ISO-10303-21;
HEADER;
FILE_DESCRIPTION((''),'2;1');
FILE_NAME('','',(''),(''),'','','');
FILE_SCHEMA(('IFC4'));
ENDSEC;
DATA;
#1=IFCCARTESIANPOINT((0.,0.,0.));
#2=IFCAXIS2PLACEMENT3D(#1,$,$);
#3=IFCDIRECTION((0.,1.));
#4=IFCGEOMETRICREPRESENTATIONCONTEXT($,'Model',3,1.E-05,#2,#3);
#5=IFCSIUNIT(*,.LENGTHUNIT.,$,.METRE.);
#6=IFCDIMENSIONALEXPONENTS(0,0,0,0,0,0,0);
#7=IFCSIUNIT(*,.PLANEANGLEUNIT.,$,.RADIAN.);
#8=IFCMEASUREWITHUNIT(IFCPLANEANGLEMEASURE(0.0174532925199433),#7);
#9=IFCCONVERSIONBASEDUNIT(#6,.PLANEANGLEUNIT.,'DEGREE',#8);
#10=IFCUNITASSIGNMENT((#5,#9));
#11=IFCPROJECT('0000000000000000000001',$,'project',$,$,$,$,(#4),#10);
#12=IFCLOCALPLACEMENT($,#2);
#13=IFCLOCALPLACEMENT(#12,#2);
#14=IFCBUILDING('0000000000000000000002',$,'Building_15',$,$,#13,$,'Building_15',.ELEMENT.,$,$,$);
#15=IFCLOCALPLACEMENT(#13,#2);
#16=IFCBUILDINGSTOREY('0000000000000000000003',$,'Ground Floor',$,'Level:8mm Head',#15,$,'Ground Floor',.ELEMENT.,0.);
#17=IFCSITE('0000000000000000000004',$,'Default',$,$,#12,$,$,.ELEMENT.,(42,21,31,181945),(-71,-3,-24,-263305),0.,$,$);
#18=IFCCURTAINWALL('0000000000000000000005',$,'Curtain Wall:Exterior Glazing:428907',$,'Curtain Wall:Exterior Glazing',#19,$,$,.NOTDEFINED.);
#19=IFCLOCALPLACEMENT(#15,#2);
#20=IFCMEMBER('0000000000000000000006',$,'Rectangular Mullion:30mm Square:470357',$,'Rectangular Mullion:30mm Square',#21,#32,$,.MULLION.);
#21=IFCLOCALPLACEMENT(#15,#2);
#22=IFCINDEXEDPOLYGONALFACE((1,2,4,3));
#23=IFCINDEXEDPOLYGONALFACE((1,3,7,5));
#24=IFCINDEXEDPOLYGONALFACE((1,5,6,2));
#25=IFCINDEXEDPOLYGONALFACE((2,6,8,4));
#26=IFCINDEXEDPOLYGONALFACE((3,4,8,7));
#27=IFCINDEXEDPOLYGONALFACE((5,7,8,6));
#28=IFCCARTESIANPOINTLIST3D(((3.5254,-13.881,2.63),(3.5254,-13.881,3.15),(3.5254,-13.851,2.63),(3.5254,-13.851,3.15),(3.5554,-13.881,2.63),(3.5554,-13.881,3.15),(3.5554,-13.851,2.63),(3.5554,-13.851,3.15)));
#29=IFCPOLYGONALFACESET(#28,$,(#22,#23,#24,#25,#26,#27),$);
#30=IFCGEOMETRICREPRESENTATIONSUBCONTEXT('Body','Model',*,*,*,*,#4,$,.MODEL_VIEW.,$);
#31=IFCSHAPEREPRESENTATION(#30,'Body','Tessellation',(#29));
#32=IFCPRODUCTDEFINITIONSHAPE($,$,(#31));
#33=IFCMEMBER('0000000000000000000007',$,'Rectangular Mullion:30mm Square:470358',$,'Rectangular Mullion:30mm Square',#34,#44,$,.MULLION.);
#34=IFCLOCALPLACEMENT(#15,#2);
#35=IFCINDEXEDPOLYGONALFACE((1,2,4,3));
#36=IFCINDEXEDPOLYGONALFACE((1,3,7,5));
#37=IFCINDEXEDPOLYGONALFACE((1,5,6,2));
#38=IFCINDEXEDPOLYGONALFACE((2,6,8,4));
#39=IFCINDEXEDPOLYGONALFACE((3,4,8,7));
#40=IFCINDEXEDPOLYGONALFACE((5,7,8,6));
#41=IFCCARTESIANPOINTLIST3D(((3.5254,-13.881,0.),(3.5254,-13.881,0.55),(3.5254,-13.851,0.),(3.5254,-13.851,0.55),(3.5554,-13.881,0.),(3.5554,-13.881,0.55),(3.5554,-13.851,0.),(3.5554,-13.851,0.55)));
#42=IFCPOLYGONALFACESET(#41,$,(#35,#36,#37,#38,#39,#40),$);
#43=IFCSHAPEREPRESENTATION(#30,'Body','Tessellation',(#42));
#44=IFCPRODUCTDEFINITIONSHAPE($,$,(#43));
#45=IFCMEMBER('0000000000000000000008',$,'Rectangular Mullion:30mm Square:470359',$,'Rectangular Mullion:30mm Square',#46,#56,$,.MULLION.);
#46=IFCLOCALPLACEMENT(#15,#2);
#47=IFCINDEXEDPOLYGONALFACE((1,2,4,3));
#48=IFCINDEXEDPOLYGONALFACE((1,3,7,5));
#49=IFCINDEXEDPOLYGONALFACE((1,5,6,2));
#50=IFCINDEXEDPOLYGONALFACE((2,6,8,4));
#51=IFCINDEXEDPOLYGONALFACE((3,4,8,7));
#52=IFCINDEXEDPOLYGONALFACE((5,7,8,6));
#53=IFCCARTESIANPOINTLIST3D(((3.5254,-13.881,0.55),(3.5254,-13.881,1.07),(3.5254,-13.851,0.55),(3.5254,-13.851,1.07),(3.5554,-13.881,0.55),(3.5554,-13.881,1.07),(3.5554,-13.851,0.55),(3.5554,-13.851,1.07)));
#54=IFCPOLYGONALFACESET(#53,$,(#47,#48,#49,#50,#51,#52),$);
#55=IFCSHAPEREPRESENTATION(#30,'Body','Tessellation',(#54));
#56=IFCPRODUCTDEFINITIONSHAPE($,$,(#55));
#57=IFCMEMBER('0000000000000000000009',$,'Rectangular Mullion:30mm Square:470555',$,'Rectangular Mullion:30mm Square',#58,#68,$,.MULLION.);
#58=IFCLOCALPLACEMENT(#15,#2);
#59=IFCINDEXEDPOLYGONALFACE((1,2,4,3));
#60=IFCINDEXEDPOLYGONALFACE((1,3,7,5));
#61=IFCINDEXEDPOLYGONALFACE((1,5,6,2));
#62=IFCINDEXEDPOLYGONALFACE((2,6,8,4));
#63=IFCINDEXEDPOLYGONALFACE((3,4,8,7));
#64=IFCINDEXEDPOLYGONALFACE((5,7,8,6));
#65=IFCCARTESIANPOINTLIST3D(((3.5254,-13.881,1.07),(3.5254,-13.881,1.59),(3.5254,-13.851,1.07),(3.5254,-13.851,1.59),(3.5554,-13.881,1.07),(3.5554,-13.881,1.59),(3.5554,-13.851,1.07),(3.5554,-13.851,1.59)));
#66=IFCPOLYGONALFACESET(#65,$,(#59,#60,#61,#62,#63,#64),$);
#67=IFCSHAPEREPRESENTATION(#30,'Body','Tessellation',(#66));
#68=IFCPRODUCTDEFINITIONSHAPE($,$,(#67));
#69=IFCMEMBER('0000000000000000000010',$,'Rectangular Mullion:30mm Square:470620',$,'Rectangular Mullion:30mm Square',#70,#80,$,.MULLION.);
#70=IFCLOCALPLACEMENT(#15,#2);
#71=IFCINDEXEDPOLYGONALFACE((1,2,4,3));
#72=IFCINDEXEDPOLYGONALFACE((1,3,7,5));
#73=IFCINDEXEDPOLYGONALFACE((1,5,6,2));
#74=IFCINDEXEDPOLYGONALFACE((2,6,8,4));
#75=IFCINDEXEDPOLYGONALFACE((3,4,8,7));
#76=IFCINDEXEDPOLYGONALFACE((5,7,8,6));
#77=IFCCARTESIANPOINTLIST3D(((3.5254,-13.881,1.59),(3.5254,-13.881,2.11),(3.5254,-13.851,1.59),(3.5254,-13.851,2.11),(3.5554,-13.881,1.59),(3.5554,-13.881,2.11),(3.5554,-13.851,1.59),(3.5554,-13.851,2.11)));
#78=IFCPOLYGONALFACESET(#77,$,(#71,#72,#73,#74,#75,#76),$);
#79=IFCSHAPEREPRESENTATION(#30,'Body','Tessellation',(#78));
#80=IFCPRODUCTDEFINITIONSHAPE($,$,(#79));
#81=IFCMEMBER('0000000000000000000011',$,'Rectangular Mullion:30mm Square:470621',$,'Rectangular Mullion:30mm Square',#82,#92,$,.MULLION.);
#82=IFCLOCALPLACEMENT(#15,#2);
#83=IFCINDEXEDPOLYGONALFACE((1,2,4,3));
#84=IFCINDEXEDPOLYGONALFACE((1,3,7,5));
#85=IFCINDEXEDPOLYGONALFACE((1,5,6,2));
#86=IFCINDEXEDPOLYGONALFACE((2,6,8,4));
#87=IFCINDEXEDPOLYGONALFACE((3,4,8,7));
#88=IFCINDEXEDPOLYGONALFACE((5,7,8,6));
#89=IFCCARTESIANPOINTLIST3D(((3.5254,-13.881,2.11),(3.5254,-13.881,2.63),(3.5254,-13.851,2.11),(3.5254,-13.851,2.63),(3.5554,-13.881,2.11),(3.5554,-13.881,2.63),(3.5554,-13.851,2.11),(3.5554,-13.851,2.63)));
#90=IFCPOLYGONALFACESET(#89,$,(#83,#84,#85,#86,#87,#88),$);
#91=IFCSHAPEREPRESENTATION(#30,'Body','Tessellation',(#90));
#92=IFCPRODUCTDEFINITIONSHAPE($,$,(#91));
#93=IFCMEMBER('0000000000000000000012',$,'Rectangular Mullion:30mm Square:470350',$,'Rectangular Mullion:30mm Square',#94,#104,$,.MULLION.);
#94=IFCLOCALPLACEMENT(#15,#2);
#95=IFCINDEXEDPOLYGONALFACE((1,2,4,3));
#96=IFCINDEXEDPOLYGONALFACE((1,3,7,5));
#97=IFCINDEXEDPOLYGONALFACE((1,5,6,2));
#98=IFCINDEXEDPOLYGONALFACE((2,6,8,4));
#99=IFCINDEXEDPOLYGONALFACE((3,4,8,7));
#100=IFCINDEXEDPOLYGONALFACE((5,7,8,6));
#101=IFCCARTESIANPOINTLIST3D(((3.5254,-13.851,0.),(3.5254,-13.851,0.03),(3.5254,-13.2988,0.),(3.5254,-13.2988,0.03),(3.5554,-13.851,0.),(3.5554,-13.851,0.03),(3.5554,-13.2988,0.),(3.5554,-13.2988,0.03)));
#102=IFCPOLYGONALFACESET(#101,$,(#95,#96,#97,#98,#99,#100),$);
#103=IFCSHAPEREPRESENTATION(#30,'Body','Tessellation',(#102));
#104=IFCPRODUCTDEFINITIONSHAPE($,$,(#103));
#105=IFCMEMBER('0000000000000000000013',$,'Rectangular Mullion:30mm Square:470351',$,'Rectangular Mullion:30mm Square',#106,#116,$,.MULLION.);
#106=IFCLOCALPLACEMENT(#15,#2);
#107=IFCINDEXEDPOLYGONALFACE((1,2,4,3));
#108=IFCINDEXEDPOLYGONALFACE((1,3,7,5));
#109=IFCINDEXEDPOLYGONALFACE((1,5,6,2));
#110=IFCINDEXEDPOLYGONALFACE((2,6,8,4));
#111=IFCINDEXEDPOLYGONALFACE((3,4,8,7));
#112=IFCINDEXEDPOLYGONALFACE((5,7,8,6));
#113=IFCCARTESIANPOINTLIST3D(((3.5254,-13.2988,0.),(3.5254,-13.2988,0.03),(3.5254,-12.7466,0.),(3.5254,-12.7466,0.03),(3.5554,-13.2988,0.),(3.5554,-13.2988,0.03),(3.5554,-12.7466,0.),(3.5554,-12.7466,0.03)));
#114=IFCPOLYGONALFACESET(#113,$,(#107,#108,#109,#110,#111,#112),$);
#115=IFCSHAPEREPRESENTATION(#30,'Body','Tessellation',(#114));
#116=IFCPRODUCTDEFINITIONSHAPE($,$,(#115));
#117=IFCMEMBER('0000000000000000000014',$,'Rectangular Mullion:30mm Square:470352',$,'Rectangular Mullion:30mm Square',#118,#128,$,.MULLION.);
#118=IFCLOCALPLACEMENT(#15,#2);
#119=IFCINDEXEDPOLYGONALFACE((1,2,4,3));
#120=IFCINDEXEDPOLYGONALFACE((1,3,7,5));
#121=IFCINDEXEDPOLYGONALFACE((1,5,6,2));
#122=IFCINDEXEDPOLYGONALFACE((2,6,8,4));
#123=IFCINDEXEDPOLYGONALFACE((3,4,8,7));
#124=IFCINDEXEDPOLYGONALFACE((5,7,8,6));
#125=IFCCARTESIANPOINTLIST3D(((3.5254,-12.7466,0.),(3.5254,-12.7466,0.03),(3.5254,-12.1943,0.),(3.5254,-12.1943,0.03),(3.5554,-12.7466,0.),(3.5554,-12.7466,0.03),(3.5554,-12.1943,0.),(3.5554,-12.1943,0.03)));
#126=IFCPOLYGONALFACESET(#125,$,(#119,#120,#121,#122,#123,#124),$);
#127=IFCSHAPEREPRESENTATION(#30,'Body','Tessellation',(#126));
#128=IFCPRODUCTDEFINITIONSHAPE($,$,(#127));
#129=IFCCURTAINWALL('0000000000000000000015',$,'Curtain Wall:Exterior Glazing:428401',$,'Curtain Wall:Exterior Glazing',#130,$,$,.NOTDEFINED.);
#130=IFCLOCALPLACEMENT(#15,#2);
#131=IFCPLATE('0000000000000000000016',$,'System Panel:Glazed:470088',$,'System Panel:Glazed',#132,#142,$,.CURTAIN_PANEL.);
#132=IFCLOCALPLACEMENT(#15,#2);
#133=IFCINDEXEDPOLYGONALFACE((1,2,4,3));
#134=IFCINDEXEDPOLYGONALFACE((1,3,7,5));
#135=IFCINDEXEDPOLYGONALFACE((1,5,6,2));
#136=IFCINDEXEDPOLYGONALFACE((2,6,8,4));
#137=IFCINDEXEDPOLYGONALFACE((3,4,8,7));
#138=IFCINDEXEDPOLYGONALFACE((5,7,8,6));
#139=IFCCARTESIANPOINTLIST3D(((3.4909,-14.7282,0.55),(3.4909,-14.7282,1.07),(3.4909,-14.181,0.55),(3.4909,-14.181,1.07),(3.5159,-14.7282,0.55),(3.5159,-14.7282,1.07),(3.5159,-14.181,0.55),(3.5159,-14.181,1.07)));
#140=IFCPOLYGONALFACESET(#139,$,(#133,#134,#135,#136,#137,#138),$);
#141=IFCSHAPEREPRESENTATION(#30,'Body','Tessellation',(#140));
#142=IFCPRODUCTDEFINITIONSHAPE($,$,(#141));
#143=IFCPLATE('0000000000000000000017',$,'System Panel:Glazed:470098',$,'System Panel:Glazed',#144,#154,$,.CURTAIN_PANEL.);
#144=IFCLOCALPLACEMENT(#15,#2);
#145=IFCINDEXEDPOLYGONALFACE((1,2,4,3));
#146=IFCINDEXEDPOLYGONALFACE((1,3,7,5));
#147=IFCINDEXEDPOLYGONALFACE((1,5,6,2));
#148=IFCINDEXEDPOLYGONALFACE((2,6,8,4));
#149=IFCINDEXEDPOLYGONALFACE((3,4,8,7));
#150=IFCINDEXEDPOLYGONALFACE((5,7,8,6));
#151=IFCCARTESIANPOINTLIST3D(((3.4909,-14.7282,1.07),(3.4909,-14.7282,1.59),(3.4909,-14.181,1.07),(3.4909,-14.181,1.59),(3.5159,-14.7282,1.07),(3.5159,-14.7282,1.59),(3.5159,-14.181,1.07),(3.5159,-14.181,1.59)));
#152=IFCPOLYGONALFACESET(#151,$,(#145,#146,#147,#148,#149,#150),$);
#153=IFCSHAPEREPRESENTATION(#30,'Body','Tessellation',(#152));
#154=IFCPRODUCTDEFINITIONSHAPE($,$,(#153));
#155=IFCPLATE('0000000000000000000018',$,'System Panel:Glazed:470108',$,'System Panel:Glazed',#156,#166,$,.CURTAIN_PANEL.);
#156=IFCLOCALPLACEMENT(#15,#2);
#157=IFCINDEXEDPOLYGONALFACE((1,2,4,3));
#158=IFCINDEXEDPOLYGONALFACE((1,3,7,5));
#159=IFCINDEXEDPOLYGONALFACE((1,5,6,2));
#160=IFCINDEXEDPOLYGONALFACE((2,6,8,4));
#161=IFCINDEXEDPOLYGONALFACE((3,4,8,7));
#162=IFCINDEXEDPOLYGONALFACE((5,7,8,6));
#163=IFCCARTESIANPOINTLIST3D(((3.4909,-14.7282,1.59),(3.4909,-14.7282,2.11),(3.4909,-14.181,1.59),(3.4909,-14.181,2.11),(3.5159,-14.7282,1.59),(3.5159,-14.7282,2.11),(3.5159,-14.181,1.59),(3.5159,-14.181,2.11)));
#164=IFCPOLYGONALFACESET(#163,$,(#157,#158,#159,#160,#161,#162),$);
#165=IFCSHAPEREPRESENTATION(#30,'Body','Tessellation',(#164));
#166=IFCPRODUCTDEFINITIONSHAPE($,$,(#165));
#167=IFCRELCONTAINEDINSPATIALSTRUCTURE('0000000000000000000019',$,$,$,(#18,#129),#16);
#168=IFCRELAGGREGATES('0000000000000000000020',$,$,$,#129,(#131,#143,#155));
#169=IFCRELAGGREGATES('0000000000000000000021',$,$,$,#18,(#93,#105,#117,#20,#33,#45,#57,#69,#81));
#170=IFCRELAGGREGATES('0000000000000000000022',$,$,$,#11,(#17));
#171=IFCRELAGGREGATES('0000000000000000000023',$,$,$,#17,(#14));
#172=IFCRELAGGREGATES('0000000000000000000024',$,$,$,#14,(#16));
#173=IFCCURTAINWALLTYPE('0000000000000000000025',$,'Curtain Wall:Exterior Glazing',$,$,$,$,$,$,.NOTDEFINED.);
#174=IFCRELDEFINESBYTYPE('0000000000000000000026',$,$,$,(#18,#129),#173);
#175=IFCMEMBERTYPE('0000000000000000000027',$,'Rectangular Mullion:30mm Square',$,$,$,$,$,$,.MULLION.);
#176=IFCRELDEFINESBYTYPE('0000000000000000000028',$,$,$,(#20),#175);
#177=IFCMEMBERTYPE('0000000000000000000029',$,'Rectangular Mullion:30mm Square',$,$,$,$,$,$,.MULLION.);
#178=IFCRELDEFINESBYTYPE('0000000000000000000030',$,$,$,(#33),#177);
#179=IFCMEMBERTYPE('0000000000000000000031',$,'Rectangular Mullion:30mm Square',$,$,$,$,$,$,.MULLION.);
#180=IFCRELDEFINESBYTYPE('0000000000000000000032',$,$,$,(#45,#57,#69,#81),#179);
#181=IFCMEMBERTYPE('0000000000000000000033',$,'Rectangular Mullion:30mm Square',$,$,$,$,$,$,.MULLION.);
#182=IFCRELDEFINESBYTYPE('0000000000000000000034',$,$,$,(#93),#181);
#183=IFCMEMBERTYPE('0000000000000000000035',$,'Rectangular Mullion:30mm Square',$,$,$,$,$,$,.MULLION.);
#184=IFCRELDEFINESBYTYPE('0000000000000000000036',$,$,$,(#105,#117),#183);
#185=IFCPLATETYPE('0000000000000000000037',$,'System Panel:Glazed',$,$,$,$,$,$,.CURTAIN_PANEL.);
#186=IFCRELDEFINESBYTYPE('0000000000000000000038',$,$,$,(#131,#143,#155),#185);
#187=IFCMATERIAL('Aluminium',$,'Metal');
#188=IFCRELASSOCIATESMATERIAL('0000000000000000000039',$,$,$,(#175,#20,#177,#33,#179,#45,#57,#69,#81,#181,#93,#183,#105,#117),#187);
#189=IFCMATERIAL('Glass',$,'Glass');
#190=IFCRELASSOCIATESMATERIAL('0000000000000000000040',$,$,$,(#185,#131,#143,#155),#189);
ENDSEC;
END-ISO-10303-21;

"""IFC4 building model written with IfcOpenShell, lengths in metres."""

from ifc_helpers import new_model, entity, si_unit, converted_unit, direction, frame, origin, place, context, subcontext, project, spatial, indexed_curve, outline, extrude, source, transform, mapped, material, type_object, type_shapes, element, aggregate, save


model = new_model("IFC4")

# Units and contexts
model_context = context("Model", 3, precision=1e-05, world=origin(), true_north=direction((0.0, 1.0)))
body_context = subcontext(model_context, "Body", "Model", "MODEL_VIEW")
ifc_project = project(units=[si_unit("LENGTHUNIT", "METRE"), converted_unit("PLANEANGLEUNIT", "DEGREE", entity("IfcPlaneAngleMeasure", 0.0174532925199433), si_unit("PLANEANGLEUNIT", "RADIAN"), dimensions=[0, 0, 0, 0, 0, 0, 0])], contexts=[model_context])

# Site, building, storey
site_placement = place(None, origin())
site = spatial("IfcSite", under=ifc_project, at=site_placement, Name="Default", CompositionType="ELEMENT", RefLatitude=(42, 21, 31, 181945), RefLongitude=(-71, -3, -24, -263305), RefElevation=0.0)
building_placement = place(site_placement, origin())
building = spatial("IfcBuilding", under=site, at=building_placement, Name="Building_15", LongName="Building_15", CompositionType="ELEMENT")
storey_placement = place(building_placement, origin())
storey = spatial("IfcBuildingStorey", under=building, at=storey_placement, Name="Ground Floor", ObjectType="Level:8mm Head", LongName="Ground Floor", CompositionType="ELEMENT", Elevation=0.0)

# Curtain wall, members
curtain_wall_type = type_object("IfcCurtainWallType", Name="Curtain Wall:Exterior Glazing", PredefinedType="NOTDEFINED")
curtain_wall_1_placement = place(storey_placement, origin())
curtain_wall_1 = element("IfcCurtainWall", 1, at=curtain_wall_1_placement, inside=storey, type_object=curtain_wall_type, Name="Curtain Wall:Exterior Glazing:428907", ObjectType="Curtain Wall:Exterior Glazing", PredefinedType="NOTDEFINED")
ifc_material_1 = material(Name="Aluminium", Category="Metal")
member_type_1 = type_object("IfcMemberType", Name="Rectangular Mullion:30mm Square", PredefinedType="MULLION", material=ifc_material_1)
shared_shape_1 = source(origin(), body_context, "Body", "SweptSolid", [
    extrude(outline(indexed_curve([(-0.015, -0.015), (0.015, -0.015), (0.015, 0.015), (-0.015, 0.015), (-0.015, -0.015)], self_intersect=False)), frame((-0.015, 0.0, -0.52), z_axis=(0.0, 0.0, 1.0), x_axis=(-1.0, 0.0, 0.0)), (0.0, 0.0, 1.0), 0.52),
])
type_shapes(member_type_1, [shared_shape_1])
member_1_placement = place(curtain_wall_1_placement, frame((3.5404, -13.881, 3.15), z_axis=(0.0, 0.0, 1.0), x_axis=(0.0, -1.0, 0.0)))
member_1 = element("IfcMember", 2, at=member_1_placement, type_object=member_type_1, material=ifc_material_1, Name="Rectangular Mullion:30mm Square:470357", ObjectType="Rectangular Mullion:30mm Square", PredefinedType="MULLION", context=body_context, shape_type="MappedRepresentation", body=[
    mapped(shared_shape_1, transform((0.0, 0.0, 0.0), scale=1.0)),
])
member_type_2 = type_object("IfcMemberType", Name="Rectangular Mullion:30mm Square", PredefinedType="MULLION", material=ifc_material_1)
shared_shape_2 = source(origin(), body_context, "Body", "SweptSolid", [
    extrude(outline(indexed_curve([(-0.015, -0.015), (0.015, -0.015), (0.015, 0.015), (-0.015, 0.015), (-0.015, -0.015)], self_intersect=False)), frame((-0.015, 0.0, -0.55), z_axis=(0.0, 0.0, 1.0), x_axis=(-1.0, 0.0, 0.0)), (0.0, 0.0, 1.0), 0.55),
])
type_shapes(member_type_2, [shared_shape_2])
member_2_placement = place(curtain_wall_1_placement, frame((3.5404, -13.881, 0.55), z_axis=(0.0, 0.0, 1.0), x_axis=(0.0, -1.0, 0.0)))
member_2 = element("IfcMember", 3, at=member_2_placement, type_object=member_type_2, material=ifc_material_1, Name="Rectangular Mullion:30mm Square:470358", ObjectType="Rectangular Mullion:30mm Square", PredefinedType="MULLION", context=body_context, shape_type="MappedRepresentation", body=[
    mapped(shared_shape_2, transform((0.0, 0.0, 0.0), scale=1.0)),
])
member_type_3 = type_object("IfcMemberType", Name="Rectangular Mullion:30mm Square", PredefinedType="MULLION", material=ifc_material_1)
shared_shape_3 = source(origin(), body_context, "Body", "SweptSolid", [
    extrude(outline(indexed_curve([(-0.015, -0.015), (0.015, -0.015), (0.015, 0.015), (-0.015, 0.015), (-0.015, -0.015)], self_intersect=False)), frame((-0.015, 0.0, -0.52), z_axis=(0.0, 0.0, 1.0), x_axis=(-1.0, 0.0, 0.0)), (0.0, 0.0, 1.0), 0.52),
])
type_shapes(member_type_3, [shared_shape_3])
member_3_placement = place(curtain_wall_1_placement, frame((3.5404, -13.881, 1.07), z_axis=(0.0, 0.0, 1.0), x_axis=(0.0, -1.0, 0.0)))
member_3 = element("IfcMember", 4, at=member_3_placement, type_object=member_type_3, material=ifc_material_1, Name="Rectangular Mullion:30mm Square:470359", ObjectType="Rectangular Mullion:30mm Square", PredefinedType="MULLION", context=body_context, shape_type="MappedRepresentation", body=[
    mapped(shared_shape_3, transform((0.0, 0.0, 0.0), scale=1.0)),
])
member_4_placement = place(curtain_wall_1_placement, frame((3.5404, -13.881, 1.59), z_axis=(0.0, 0.0, 1.0), x_axis=(0.0, -1.0, 0.0)))
member_4 = element("IfcMember", 5, at=member_4_placement, type_object=member_type_3, material=ifc_material_1, Name="Rectangular Mullion:30mm Square:470555", ObjectType="Rectangular Mullion:30mm Square", PredefinedType="MULLION", context=body_context, shape_type="MappedRepresentation", body=[
    mapped(shared_shape_3, transform((0.0, 0.0, 0.0), scale=1.0)),
])
member_5_placement = place(curtain_wall_1_placement, frame((3.5404, -13.881, 2.11), z_axis=(0.0, 0.0, 1.0), x_axis=(0.0, -1.0, 0.0)))
member_5 = element("IfcMember", 6, at=member_5_placement, type_object=member_type_3, material=ifc_material_1, Name="Rectangular Mullion:30mm Square:470620", ObjectType="Rectangular Mullion:30mm Square", PredefinedType="MULLION", context=body_context, shape_type="MappedRepresentation", body=[
    mapped(shared_shape_3, transform((0.0, 0.0, 0.0), scale=1.0)),
])
member_6_placement = place(curtain_wall_1_placement, frame((3.5404, -13.881, 2.63), z_axis=(0.0, 0.0, 1.0), x_axis=(0.0, -1.0, 0.0)))
member_6 = element("IfcMember", 7, at=member_6_placement, type_object=member_type_3, material=ifc_material_1, Name="Rectangular Mullion:30mm Square:470621", ObjectType="Rectangular Mullion:30mm Square", PredefinedType="MULLION", context=body_context, shape_type="MappedRepresentation", body=[
    mapped(shared_shape_3, transform((0.0, 0.0, 0.0), scale=1.0)),
])
member_type_4 = type_object("IfcMemberType", Name="Rectangular Mullion:30mm Square", PredefinedType="MULLION", material=ifc_material_1)
shared_shape_4 = source(origin(), body_context, "Body", "SweptSolid", [
    extrude(outline(indexed_curve([(-0.015, -0.015), (0.015, -0.015), (0.015, 0.015), (-0.015, 0.015), (-0.015, -0.015)], self_intersect=False)), frame((-0.015, 0.0, -0.5522), z_axis=(0.0, 0.0, 1.0), x_axis=(-1.0, 0.0, 0.0)), (0.0, 0.0, 1.0), 0.5522),
])
type_shapes(member_type_4, [shared_shape_4])
member_7_placement = place(curtain_wall_1_placement, frame((3.5404, -13.851, 0.0), z_axis=(0.0, -1.0, 0.0), x_axis=(0.0, 0.0, -1.0)))
member_7 = element("IfcMember", 8, at=member_7_placement, type_object=member_type_4, material=ifc_material_1, Name="Rectangular Mullion:30mm Square:470350", ObjectType="Rectangular Mullion:30mm Square", PredefinedType="MULLION", context=body_context, shape_type="MappedRepresentation", body=[
    mapped(shared_shape_4, transform((0.0, 0.0, 0.0), scale=1.0)),
])
member_type_5 = type_object("IfcMemberType", Name="Rectangular Mullion:30mm Square", PredefinedType="MULLION", material=ifc_material_1)
shared_shape_5 = source(origin(), body_context, "Body", "SweptSolid", [
    extrude(outline(indexed_curve([(-0.015, -0.015), (0.015, -0.015), (0.015, 0.015), (-0.015, 0.015), (-0.015, -0.015)], self_intersect=False)), frame((-0.015, 0.0, -0.5522), z_axis=(0.0, 0.0, 1.0), x_axis=(-1.0, 0.0, 0.0)), (0.0, 0.0, 1.0), 0.5522),
])
type_shapes(member_type_5, [shared_shape_5])
member_8_placement = place(curtain_wall_1_placement, frame((3.5404, -13.2988, 0.0), z_axis=(0.0, -1.0, 0.0), x_axis=(0.0, 0.0, -1.0)))
member_8 = element("IfcMember", 9, at=member_8_placement, type_object=member_type_5, material=ifc_material_1, Name="Rectangular Mullion:30mm Square:470351", ObjectType="Rectangular Mullion:30mm Square", PredefinedType="MULLION", context=body_context, shape_type="MappedRepresentation", body=[
    mapped(shared_shape_5, transform((0.0, 0.0, 0.0), scale=1.0)),
])
member_9_placement = place(curtain_wall_1_placement, frame((3.5404, -12.7466, 0.0), z_axis=(0.0, -1.0, 0.0), x_axis=(0.0, 0.0, -1.0)))
member_9 = element("IfcMember", 10, at=member_9_placement, type_object=member_type_5, material=ifc_material_1, Name="Rectangular Mullion:30mm Square:470352", ObjectType="Rectangular Mullion:30mm Square", PredefinedType="MULLION", context=body_context, shape_type="MappedRepresentation", body=[
    mapped(shared_shape_5, transform((0.0, 0.0, 0.0), scale=1.0)),
])

# Curtain wall, plates
curtain_wall_2_placement = place(storey_placement, origin())
curtain_wall_2 = element("IfcCurtainWall", 11, at=curtain_wall_2_placement, inside=storey, type_object=curtain_wall_type, Name="Curtain Wall:Exterior Glazing:428401", ObjectType="Curtain Wall:Exterior Glazing", PredefinedType="NOTDEFINED")
ifc_material_2 = material(Name="Glass", Category="Glass")
plate_type_1 = type_object("IfcPlateType", Name="System Panel:Glazed", PredefinedType="CURTAIN_PANEL", material=ifc_material_2)
shared_shape_6 = source(origin(), body_context, "Body", "SweptSolid", [
    extrude(outline(indexed_curve([(-0.0125, -0.2736), (0.0125, -0.2736), (0.0125, 0.2736), (-0.0125, 0.2736), (-0.0125, -0.2736)], self_intersect=False)), frame((0.0, 0.037, 0.0), z_axis=(0.0, 0.0, 1.0), x_axis=(0.0, 1.0, 0.0)), (0.0, 0.0, 1.0), 0.52),
])
type_shapes(plate_type_1, [shared_shape_6])
plate_1_placement = place(curtain_wall_2_placement, frame((3.5404, -14.4546, 0.55), z_axis=(0.0, 0.0, 1.0), x_axis=(0.0, 1.0, 0.0)))
plate_1 = element("IfcPlate", 12, at=plate_1_placement, type_object=plate_type_1, material=ifc_material_2, Name="System Panel:Glazed:470088", ObjectType="System Panel:Glazed", PredefinedType="CURTAIN_PANEL", context=body_context, shape_type="MappedRepresentation", body=[
    mapped(shared_shape_6, transform((0.0, 0.0, 0.0), scale=1.0)),
])
plate_2_placement = place(curtain_wall_2_placement, frame((3.5404, -14.4546, 1.07), z_axis=(0.0, 0.0, 1.0), x_axis=(0.0, 1.0, 0.0)))
plate_2 = element("IfcPlate", 13, at=plate_2_placement, type_object=plate_type_1, material=ifc_material_2, Name="System Panel:Glazed:470098", ObjectType="System Panel:Glazed", PredefinedType="CURTAIN_PANEL", context=body_context, shape_type="MappedRepresentation", body=[
    mapped(shared_shape_6, transform((0.0, 0.0, 0.0), scale=1.0)),
])
plate_3_placement = place(curtain_wall_2_placement, frame((3.5404, -14.4546, 1.59), z_axis=(0.0, 0.0, 1.0), x_axis=(0.0, 1.0, 0.0)))
plate_3 = element("IfcPlate", 14, at=plate_3_placement, type_object=plate_type_1, material=ifc_material_2, Name="System Panel:Glazed:470108", ObjectType="System Panel:Glazed", PredefinedType="CURTAIN_PANEL", context=body_context, shape_type="MappedRepresentation", body=[
    mapped(shared_shape_6, transform((0.0, 0.0, 0.0), scale=1.0)),
])
aggregate(curtain_wall_2, [plate_1, plate_2, plate_3])

aggregate(curtain_wall_1, [member_7, member_8, member_9, member_1, member_2, member_3, member_4, member_5, member_6])

save(model, "model.ifc")
